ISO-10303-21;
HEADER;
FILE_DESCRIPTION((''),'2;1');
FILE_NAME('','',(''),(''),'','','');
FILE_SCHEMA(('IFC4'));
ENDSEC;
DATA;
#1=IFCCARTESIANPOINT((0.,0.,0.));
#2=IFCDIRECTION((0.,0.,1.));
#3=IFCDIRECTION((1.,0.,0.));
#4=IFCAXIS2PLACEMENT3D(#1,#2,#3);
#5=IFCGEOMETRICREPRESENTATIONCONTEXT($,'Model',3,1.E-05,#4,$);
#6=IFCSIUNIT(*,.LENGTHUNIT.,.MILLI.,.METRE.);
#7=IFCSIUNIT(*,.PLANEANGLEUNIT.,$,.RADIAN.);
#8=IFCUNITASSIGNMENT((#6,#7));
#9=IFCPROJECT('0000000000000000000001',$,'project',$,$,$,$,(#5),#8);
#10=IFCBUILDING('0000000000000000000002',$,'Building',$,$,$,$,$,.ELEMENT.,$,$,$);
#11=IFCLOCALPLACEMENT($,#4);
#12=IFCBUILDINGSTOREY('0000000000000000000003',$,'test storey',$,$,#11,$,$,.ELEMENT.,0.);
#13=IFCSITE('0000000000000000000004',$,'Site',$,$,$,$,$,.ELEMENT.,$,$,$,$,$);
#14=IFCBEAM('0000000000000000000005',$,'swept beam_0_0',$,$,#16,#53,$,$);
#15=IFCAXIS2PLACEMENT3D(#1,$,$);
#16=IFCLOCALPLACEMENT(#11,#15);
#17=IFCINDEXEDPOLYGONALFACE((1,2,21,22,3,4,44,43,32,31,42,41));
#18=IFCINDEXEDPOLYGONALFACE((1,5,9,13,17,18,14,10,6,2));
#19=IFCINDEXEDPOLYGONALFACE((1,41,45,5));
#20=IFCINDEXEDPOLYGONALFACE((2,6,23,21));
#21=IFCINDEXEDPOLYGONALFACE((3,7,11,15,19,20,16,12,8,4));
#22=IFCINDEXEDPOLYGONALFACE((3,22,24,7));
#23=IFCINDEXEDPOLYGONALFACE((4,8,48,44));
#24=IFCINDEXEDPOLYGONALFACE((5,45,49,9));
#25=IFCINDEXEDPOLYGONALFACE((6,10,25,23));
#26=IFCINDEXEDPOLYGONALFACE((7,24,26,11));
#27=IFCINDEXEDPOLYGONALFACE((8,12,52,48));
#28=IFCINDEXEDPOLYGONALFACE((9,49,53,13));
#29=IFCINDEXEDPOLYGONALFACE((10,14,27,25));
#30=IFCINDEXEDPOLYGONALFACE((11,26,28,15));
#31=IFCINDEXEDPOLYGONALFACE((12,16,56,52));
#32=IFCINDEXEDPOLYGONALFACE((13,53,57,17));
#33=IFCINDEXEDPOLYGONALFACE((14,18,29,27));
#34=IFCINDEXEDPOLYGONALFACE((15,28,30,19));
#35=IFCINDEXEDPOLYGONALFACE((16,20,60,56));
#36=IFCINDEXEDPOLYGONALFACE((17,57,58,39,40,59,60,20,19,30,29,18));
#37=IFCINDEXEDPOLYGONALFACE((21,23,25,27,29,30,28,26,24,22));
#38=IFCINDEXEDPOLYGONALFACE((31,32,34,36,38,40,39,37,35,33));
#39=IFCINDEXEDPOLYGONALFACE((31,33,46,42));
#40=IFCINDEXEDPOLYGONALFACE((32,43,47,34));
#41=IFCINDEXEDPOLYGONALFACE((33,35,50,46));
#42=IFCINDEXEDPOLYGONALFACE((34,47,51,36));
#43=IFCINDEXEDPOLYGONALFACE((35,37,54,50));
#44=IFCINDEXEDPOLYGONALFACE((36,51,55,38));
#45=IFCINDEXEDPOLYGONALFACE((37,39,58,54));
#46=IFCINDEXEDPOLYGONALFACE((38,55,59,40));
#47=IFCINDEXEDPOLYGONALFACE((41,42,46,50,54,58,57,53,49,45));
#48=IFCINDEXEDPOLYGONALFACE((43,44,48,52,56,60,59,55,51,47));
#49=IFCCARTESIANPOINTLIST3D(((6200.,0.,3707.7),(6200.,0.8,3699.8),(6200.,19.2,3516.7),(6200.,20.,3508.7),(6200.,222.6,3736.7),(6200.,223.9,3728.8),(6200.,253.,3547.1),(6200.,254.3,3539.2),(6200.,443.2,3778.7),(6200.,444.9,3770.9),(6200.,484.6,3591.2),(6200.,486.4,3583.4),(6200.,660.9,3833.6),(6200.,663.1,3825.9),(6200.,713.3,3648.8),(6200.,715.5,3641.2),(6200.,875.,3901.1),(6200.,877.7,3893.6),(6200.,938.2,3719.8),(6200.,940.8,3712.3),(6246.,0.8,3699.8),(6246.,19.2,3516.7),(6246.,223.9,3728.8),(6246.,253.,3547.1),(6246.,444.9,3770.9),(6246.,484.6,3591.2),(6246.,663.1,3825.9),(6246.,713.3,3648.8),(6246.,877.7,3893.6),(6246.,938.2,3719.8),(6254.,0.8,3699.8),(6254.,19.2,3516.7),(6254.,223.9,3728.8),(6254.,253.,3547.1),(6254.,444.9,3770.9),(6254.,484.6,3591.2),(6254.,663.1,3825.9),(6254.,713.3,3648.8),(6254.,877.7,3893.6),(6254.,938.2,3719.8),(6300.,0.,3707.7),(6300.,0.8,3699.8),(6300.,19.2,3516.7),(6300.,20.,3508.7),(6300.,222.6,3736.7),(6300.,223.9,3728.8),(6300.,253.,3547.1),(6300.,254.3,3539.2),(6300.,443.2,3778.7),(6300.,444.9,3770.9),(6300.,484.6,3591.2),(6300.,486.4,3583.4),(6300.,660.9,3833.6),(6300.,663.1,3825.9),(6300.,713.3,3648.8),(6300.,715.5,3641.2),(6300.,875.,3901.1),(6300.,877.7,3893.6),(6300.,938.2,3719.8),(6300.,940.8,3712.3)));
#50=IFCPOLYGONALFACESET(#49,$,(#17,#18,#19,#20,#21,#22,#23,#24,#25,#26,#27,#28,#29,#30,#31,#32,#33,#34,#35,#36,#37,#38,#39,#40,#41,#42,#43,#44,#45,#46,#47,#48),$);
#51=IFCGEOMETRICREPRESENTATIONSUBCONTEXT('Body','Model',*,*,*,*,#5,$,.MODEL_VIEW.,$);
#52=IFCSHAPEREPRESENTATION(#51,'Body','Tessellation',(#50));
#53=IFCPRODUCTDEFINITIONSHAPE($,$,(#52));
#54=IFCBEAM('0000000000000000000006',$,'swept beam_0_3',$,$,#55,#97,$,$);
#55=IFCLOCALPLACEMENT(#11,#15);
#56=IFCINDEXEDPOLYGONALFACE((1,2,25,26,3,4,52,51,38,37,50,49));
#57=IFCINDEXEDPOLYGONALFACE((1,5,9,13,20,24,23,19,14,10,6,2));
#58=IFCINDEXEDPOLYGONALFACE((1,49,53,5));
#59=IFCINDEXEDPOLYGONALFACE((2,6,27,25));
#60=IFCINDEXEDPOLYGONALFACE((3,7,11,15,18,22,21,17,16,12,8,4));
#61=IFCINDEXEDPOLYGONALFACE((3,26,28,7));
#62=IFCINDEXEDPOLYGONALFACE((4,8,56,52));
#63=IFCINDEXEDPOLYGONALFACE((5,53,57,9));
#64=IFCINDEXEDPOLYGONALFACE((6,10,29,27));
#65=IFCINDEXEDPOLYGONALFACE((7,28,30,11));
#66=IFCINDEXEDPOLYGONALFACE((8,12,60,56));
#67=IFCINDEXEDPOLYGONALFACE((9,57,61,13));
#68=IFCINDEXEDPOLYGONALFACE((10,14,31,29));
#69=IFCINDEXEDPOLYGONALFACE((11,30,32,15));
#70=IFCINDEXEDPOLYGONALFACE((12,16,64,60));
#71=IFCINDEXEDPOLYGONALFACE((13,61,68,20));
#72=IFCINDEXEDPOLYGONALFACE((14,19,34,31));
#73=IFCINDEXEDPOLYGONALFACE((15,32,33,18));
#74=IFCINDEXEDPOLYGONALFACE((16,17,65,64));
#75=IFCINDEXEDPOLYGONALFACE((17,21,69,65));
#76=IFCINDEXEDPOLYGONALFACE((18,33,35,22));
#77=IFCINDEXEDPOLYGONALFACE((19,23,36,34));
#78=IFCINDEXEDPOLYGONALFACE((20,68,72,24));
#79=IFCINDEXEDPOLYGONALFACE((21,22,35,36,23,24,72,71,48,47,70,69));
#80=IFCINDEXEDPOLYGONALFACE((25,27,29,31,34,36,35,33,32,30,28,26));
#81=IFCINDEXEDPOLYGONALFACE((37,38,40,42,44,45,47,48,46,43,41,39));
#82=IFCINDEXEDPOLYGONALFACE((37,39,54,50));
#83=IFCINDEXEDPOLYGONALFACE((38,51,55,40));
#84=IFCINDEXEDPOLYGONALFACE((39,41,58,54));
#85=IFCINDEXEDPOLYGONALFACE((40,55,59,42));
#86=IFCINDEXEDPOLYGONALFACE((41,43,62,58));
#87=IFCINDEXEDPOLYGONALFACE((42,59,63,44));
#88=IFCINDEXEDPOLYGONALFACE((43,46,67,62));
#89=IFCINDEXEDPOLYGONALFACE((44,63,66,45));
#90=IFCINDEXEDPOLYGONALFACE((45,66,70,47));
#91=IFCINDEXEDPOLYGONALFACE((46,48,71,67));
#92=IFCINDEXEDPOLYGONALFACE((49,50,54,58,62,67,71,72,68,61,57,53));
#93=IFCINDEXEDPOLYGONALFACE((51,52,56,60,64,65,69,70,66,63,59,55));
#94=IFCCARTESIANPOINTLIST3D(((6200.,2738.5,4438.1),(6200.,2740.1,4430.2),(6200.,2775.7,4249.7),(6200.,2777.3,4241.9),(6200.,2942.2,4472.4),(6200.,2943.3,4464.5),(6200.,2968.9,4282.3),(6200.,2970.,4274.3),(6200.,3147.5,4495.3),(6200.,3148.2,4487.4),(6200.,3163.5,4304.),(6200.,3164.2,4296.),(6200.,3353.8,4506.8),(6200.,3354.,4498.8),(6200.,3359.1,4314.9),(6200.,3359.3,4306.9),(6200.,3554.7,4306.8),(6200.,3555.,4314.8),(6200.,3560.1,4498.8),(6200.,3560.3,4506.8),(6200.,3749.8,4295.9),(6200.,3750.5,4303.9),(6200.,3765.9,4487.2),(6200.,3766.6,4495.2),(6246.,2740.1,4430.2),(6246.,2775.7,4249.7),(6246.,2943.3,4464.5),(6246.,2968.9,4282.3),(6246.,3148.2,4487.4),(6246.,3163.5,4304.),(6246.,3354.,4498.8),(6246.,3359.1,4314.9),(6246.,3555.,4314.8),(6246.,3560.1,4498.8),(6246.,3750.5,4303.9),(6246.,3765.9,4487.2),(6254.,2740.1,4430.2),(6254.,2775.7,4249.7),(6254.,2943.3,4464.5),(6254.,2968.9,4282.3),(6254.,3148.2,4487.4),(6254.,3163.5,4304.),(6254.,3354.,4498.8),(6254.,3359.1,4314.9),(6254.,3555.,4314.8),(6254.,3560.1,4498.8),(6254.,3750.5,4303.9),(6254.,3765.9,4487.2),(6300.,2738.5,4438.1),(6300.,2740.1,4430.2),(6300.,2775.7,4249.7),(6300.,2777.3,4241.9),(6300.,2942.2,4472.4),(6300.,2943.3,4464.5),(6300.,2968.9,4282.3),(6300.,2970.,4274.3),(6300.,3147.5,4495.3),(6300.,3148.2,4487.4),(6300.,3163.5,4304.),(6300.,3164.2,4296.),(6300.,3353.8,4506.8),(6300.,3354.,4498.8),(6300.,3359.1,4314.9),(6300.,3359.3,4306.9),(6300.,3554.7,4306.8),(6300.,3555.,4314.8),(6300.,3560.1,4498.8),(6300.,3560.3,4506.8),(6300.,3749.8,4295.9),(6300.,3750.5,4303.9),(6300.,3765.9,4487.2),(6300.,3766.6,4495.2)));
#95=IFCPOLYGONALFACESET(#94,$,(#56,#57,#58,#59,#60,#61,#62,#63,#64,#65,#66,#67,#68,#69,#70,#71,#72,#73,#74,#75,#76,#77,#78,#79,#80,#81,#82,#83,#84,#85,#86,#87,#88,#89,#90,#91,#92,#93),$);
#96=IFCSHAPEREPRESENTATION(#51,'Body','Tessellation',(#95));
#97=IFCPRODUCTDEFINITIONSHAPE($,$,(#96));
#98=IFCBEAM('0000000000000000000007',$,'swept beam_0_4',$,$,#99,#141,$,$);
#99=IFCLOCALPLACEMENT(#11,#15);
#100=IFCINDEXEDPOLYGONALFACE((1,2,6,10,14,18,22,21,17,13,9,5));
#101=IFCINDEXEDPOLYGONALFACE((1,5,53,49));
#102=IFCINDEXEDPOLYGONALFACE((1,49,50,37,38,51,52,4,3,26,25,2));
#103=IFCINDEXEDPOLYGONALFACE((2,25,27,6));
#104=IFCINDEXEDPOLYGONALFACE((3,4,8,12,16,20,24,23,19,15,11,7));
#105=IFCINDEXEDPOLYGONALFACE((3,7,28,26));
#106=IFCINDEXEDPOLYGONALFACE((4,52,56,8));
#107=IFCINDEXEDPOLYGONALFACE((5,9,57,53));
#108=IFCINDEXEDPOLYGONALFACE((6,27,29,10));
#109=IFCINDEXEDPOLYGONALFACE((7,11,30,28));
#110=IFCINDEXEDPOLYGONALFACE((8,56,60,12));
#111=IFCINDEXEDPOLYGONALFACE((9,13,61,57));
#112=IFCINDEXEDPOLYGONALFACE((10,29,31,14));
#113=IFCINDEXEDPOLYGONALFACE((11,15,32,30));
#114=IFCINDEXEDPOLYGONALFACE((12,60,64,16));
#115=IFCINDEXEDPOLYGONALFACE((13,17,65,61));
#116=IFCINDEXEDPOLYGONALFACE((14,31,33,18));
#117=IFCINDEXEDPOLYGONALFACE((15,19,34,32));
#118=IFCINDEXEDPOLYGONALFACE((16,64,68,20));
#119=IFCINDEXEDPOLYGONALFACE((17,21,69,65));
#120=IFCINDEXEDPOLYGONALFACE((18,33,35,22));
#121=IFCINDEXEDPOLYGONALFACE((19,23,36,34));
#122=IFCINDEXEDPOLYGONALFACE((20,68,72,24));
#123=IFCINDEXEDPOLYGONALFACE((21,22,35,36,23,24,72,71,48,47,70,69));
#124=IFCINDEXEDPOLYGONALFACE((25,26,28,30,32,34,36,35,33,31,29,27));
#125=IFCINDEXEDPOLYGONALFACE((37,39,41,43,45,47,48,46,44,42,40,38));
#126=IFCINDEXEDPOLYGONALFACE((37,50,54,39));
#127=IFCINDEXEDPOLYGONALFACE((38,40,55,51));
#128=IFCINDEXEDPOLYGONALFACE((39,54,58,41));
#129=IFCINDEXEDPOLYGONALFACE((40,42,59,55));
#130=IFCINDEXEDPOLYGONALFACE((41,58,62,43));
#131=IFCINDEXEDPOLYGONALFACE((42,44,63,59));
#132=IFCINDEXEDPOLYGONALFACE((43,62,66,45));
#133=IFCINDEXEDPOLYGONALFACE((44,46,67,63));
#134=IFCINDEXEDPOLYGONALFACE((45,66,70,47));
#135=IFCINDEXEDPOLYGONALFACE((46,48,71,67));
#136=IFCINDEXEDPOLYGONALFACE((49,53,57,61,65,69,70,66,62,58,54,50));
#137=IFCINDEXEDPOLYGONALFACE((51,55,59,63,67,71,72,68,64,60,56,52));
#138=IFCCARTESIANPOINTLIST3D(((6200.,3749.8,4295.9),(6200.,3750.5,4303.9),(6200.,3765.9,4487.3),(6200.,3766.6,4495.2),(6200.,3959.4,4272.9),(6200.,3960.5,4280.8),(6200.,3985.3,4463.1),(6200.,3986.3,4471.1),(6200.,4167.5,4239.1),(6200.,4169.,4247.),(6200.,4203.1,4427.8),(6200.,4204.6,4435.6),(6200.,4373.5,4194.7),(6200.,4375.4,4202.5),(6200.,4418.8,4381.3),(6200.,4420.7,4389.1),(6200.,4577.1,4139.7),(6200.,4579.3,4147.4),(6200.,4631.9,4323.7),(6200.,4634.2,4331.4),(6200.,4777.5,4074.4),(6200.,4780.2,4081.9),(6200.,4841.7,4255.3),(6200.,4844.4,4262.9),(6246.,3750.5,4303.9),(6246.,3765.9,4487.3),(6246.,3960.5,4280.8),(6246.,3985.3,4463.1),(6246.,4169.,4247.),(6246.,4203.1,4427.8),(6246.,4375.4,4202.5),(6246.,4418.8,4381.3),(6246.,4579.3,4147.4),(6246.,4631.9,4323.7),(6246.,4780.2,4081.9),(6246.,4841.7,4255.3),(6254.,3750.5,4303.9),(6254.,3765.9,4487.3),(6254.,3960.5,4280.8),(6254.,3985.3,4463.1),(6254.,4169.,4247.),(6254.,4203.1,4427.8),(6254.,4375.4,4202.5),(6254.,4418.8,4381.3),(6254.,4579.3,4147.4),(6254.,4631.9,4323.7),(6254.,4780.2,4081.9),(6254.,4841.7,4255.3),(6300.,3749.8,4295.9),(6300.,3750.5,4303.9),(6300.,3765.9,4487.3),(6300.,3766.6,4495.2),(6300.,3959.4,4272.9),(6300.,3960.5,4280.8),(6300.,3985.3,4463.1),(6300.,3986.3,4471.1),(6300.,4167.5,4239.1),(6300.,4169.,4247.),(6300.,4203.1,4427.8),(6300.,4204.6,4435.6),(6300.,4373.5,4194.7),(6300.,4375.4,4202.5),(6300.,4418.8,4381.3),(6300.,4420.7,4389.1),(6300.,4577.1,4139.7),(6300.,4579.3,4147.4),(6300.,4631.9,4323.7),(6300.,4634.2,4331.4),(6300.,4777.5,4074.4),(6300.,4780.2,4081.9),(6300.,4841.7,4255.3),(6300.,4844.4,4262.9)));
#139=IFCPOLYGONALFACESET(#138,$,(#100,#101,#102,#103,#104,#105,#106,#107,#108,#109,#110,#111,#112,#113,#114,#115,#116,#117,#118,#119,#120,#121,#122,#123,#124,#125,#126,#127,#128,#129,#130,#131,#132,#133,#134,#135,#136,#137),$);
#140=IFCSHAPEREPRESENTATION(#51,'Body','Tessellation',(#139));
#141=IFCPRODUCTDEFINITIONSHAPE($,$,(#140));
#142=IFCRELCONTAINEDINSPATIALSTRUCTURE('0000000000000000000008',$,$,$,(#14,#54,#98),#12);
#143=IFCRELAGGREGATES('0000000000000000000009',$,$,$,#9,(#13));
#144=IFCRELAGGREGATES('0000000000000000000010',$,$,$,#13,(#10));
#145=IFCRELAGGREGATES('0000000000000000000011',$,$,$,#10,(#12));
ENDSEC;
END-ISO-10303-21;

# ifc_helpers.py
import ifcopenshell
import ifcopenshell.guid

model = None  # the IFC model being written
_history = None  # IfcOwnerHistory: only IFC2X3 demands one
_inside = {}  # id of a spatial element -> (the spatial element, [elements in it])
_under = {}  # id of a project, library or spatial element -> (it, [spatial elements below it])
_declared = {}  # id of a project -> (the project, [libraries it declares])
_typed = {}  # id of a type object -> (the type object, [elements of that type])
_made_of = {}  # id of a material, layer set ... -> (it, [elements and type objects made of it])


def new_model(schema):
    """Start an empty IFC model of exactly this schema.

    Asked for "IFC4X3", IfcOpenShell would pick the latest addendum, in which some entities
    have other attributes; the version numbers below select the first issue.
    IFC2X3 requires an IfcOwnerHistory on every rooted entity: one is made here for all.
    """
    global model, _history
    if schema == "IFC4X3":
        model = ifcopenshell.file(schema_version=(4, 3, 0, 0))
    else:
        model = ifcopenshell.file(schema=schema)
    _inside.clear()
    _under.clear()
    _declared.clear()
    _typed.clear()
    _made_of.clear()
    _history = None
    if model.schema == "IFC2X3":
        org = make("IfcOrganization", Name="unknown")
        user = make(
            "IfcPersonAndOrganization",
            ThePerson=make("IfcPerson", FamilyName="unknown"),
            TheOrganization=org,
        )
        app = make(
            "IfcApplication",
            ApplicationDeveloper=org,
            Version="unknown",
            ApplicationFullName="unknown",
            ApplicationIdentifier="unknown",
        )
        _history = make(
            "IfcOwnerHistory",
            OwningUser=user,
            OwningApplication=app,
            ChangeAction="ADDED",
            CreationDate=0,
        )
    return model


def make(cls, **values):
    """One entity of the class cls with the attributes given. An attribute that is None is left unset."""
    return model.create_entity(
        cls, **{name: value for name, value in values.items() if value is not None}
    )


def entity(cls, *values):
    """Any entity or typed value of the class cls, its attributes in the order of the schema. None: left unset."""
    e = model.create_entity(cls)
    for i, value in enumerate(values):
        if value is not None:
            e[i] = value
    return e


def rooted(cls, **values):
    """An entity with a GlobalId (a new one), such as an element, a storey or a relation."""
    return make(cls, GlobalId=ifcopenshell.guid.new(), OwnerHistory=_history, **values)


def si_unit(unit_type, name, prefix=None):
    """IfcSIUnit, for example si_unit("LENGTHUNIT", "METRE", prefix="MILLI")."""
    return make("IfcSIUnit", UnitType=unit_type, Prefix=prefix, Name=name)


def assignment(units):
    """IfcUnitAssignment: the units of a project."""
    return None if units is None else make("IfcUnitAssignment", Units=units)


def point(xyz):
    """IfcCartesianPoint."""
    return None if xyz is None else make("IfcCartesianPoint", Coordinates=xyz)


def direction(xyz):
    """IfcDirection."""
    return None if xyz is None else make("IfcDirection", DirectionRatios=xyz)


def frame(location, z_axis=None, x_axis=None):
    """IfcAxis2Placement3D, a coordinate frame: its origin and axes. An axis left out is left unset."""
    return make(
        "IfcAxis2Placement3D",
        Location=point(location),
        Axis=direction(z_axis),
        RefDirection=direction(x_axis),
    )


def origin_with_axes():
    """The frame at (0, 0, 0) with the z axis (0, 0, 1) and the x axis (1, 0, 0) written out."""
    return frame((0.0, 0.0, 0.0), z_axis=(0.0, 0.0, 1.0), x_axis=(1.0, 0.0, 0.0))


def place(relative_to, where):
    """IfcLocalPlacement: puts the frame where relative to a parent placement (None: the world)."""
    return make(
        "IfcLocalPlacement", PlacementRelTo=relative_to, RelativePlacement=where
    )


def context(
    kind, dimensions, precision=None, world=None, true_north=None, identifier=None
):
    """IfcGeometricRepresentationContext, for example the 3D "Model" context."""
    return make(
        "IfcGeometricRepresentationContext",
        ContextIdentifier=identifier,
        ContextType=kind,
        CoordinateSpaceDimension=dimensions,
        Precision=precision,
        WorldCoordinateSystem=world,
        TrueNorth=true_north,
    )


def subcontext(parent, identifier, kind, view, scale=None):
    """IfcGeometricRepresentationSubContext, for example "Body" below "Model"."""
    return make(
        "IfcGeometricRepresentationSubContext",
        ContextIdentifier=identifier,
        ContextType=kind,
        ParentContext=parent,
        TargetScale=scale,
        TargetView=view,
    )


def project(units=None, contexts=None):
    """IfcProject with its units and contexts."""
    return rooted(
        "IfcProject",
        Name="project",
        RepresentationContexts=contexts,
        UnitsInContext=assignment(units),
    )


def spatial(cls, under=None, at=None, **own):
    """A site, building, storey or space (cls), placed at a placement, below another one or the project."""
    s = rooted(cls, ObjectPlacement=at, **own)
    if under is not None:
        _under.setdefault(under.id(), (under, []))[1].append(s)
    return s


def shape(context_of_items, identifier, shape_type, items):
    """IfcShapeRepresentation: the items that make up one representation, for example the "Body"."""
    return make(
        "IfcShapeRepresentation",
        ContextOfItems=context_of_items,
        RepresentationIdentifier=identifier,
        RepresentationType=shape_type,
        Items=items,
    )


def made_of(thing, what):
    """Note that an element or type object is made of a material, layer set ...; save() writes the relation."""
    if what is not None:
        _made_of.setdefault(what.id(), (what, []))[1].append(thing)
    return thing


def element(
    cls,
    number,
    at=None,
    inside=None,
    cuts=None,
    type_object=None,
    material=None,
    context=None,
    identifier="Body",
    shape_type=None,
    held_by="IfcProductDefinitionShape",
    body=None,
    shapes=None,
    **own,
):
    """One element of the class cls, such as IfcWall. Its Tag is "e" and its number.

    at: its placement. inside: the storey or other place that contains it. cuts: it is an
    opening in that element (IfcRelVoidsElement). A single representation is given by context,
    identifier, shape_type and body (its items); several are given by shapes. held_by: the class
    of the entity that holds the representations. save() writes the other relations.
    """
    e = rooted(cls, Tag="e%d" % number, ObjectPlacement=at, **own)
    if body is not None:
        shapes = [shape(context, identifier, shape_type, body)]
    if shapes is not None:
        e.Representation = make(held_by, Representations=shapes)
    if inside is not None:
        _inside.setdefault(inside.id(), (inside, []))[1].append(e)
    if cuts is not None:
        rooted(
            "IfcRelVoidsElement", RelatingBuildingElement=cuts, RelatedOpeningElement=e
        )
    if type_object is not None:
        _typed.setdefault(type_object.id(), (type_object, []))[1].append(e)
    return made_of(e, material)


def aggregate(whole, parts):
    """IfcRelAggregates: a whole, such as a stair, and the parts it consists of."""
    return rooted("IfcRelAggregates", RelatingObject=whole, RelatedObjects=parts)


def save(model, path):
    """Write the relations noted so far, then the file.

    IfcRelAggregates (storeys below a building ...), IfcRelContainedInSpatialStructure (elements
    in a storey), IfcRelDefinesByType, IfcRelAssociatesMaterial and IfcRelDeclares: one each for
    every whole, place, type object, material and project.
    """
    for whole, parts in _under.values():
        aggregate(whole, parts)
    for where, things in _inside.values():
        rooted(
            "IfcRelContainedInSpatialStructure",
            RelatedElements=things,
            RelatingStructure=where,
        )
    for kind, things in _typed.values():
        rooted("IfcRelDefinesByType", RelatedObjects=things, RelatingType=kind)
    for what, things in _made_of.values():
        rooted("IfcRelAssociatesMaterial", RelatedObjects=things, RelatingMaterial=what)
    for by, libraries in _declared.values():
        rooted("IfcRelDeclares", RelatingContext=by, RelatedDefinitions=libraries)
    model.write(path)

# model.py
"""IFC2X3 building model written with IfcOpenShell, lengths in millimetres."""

from ifc_helpers import new_model, entity, si_unit, origin_with_axes, place, context, subcontext, project, spatial, element, save


model = new_model("IFC2X3")

# Units and contexts
model_context = context("Model", 3, precision=1e-05, world=origin_with_axes())
body_context = subcontext(model_context, "Body", "Model", "MODEL_VIEW")
ifc_project = project(units=[si_unit("LENGTHUNIT", "METRE", prefix="MILLI"), si_unit("PLANEANGLEUNIT", "RADIAN")], contexts=[model_context])

# Site, building, storey
site = spatial("IfcSite", under=ifc_project, Name="Site", CompositionType="ELEMENT")
building = spatial("IfcBuilding", under=site, Name="Building", CompositionType="ELEMENT")
storey_placement = place(None, origin_with_axes())
storey = spatial("IfcBuildingStorey", under=building, at=storey_placement, Name="test storey", CompositionType="ELEMENT", Elevation=0.0)

# Beams
beam_1_placement = place(storey_placement, origin_with_axes())
element("IfcBeam", 1, at=beam_1_placement, inside=storey, Name="swept beam_0_0", context=body_context, shape_type="SweptSolid", body=[
    entity("IfcRevolvedAreaSolid", entity("IfcArbitraryClosedProfileDef", "AREA", None, entity("IfcPolyline", [entity("IfcCartesianPoint", [192.0, 50.0]), entity("IfcCartesianPoint", [192.0, 4.0]), entity("IfcCartesianPoint", [8.0, 4.0]), entity("IfcCartesianPoint", [8.0, 50.0]), entity("IfcCartesianPoint", [0.0, 50.0]), entity("IfcCartesianPoint", [0.0, -50.0]), entity("IfcCartesianPoint", [8.0, -50.0]), entity("IfcCartesianPoint", [8.0, -4.0]), entity("IfcCartesianPoint", [192.0, -4.0]), entity("IfcCartesianPoint", [192.0, -50.0]), entity("IfcCartesianPoint", [200.0, -50.0]), entity("IfcCartesianPoint", [200.0, 50.0]), entity("IfcCartesianPoint", [192.0, 50.0])])), entity("IfcAxis2Placement3D", entity("IfcCartesianPoint", [6250.0, 0.0, 3707.7]), entity("IfcDirection", [0.0, -0.995, -0.0998]), entity("IfcDirection", [0.0, 0.0998, -0.995])), entity("IfcAxis1Placement", entity("IfcCartesianPoint", [-3821.0, 0.0, 0.0]), entity("IfcDirection", [0.0, 1.0, 0.0])), 0.235073),
])
beam_2_placement = place(storey_placement, origin_with_axes())
element("IfcBeam", 2, at=beam_2_placement, inside=storey, Name="swept beam_0_3", context=body_context, shape_type="SweptSolid", body=[
    entity("IfcRevolvedAreaSolid", entity("IfcArbitraryClosedProfileDef", "AREA", None, entity("IfcPolyline", [entity("IfcCartesianPoint", [-192.0, -50.0]), entity("IfcCartesianPoint", [-192.0, -4.0]), entity("IfcCartesianPoint", [-8.0, -4.0]), entity("IfcCartesianPoint", [-8.0, -50.0]), entity("IfcCartesianPoint", [0.0, -50.0]), entity("IfcCartesianPoint", [0.0, 50.0]), entity("IfcCartesianPoint", [-8.0, 50.0]), entity("IfcCartesianPoint", [-8.0, 4.0]), entity("IfcCartesianPoint", [-192.0, 4.0]), entity("IfcCartesianPoint", [-192.0, 50.0]), entity("IfcCartesianPoint", [-200.0, 50.0]), entity("IfcCartesianPoint", [-200.0, -50.0]), entity("IfcCartesianPoint", [-192.0, -50.0])])), entity("IfcAxis2Placement3D", entity("IfcCartesianPoint", [6250.0, 2738.5, 4438.1]), entity("IfcDirection", [0.0, -0.9811, -0.1936]), entity("IfcDirection", [0.0, -0.1936, 0.9811])), entity("IfcAxis1Placement", entity("IfcCartesianPoint", [-3707.6, 0.0, 0.0]), entity("IfcDirection", [0.0, 1.0, 0.0])), 0.278607),
])
beam_3_placement = place(storey_placement, origin_with_axes())
element("IfcBeam", 3, at=beam_3_placement, inside=storey, Name="swept beam_0_4", context=body_context, shape_type="SweptSolid", body=[
    entity("IfcRevolvedAreaSolid", entity("IfcArbitraryClosedProfileDef", "AREA", None, entity("IfcPolyline", [entity("IfcCartesianPoint", [-192.0, -50.0]), entity("IfcCartesianPoint", [-192.0, -4.0]), entity("IfcCartesianPoint", [-8.0, -4.0]), entity("IfcCartesianPoint", [-8.0, -50.0]), entity("IfcCartesianPoint", [0.0, -50.0]), entity("IfcCartesianPoint", [0.0, 50.0]), entity("IfcCartesianPoint", [-8.0, 50.0]), entity("IfcCartesianPoint", [-8.0, 4.0]), entity("IfcCartesianPoint", [-192.0, 4.0]), entity("IfcCartesianPoint", [-192.0, 50.0]), entity("IfcCartesianPoint", [-200.0, 50.0]), entity("IfcCartesianPoint", [-200.0, -50.0]), entity("IfcCartesianPoint", [-192.0, -50.0])])), entity("IfcAxis2Placement3D", entity("IfcCartesianPoint", [6250.0, 3766.6, 4495.2]), entity("IfcDirection", [0.0, -0.9965, 0.0837]), entity("IfcDirection", [0.0, 0.0837, 0.9965])), entity("IfcAxis1Placement", entity("IfcCartesianPoint", [-4300.6, 0.0, 0.0]), entity("IfcDirection", [0.0, 1.0, 0.0])), 0.257076),
])

save(model, "model.ifc")
